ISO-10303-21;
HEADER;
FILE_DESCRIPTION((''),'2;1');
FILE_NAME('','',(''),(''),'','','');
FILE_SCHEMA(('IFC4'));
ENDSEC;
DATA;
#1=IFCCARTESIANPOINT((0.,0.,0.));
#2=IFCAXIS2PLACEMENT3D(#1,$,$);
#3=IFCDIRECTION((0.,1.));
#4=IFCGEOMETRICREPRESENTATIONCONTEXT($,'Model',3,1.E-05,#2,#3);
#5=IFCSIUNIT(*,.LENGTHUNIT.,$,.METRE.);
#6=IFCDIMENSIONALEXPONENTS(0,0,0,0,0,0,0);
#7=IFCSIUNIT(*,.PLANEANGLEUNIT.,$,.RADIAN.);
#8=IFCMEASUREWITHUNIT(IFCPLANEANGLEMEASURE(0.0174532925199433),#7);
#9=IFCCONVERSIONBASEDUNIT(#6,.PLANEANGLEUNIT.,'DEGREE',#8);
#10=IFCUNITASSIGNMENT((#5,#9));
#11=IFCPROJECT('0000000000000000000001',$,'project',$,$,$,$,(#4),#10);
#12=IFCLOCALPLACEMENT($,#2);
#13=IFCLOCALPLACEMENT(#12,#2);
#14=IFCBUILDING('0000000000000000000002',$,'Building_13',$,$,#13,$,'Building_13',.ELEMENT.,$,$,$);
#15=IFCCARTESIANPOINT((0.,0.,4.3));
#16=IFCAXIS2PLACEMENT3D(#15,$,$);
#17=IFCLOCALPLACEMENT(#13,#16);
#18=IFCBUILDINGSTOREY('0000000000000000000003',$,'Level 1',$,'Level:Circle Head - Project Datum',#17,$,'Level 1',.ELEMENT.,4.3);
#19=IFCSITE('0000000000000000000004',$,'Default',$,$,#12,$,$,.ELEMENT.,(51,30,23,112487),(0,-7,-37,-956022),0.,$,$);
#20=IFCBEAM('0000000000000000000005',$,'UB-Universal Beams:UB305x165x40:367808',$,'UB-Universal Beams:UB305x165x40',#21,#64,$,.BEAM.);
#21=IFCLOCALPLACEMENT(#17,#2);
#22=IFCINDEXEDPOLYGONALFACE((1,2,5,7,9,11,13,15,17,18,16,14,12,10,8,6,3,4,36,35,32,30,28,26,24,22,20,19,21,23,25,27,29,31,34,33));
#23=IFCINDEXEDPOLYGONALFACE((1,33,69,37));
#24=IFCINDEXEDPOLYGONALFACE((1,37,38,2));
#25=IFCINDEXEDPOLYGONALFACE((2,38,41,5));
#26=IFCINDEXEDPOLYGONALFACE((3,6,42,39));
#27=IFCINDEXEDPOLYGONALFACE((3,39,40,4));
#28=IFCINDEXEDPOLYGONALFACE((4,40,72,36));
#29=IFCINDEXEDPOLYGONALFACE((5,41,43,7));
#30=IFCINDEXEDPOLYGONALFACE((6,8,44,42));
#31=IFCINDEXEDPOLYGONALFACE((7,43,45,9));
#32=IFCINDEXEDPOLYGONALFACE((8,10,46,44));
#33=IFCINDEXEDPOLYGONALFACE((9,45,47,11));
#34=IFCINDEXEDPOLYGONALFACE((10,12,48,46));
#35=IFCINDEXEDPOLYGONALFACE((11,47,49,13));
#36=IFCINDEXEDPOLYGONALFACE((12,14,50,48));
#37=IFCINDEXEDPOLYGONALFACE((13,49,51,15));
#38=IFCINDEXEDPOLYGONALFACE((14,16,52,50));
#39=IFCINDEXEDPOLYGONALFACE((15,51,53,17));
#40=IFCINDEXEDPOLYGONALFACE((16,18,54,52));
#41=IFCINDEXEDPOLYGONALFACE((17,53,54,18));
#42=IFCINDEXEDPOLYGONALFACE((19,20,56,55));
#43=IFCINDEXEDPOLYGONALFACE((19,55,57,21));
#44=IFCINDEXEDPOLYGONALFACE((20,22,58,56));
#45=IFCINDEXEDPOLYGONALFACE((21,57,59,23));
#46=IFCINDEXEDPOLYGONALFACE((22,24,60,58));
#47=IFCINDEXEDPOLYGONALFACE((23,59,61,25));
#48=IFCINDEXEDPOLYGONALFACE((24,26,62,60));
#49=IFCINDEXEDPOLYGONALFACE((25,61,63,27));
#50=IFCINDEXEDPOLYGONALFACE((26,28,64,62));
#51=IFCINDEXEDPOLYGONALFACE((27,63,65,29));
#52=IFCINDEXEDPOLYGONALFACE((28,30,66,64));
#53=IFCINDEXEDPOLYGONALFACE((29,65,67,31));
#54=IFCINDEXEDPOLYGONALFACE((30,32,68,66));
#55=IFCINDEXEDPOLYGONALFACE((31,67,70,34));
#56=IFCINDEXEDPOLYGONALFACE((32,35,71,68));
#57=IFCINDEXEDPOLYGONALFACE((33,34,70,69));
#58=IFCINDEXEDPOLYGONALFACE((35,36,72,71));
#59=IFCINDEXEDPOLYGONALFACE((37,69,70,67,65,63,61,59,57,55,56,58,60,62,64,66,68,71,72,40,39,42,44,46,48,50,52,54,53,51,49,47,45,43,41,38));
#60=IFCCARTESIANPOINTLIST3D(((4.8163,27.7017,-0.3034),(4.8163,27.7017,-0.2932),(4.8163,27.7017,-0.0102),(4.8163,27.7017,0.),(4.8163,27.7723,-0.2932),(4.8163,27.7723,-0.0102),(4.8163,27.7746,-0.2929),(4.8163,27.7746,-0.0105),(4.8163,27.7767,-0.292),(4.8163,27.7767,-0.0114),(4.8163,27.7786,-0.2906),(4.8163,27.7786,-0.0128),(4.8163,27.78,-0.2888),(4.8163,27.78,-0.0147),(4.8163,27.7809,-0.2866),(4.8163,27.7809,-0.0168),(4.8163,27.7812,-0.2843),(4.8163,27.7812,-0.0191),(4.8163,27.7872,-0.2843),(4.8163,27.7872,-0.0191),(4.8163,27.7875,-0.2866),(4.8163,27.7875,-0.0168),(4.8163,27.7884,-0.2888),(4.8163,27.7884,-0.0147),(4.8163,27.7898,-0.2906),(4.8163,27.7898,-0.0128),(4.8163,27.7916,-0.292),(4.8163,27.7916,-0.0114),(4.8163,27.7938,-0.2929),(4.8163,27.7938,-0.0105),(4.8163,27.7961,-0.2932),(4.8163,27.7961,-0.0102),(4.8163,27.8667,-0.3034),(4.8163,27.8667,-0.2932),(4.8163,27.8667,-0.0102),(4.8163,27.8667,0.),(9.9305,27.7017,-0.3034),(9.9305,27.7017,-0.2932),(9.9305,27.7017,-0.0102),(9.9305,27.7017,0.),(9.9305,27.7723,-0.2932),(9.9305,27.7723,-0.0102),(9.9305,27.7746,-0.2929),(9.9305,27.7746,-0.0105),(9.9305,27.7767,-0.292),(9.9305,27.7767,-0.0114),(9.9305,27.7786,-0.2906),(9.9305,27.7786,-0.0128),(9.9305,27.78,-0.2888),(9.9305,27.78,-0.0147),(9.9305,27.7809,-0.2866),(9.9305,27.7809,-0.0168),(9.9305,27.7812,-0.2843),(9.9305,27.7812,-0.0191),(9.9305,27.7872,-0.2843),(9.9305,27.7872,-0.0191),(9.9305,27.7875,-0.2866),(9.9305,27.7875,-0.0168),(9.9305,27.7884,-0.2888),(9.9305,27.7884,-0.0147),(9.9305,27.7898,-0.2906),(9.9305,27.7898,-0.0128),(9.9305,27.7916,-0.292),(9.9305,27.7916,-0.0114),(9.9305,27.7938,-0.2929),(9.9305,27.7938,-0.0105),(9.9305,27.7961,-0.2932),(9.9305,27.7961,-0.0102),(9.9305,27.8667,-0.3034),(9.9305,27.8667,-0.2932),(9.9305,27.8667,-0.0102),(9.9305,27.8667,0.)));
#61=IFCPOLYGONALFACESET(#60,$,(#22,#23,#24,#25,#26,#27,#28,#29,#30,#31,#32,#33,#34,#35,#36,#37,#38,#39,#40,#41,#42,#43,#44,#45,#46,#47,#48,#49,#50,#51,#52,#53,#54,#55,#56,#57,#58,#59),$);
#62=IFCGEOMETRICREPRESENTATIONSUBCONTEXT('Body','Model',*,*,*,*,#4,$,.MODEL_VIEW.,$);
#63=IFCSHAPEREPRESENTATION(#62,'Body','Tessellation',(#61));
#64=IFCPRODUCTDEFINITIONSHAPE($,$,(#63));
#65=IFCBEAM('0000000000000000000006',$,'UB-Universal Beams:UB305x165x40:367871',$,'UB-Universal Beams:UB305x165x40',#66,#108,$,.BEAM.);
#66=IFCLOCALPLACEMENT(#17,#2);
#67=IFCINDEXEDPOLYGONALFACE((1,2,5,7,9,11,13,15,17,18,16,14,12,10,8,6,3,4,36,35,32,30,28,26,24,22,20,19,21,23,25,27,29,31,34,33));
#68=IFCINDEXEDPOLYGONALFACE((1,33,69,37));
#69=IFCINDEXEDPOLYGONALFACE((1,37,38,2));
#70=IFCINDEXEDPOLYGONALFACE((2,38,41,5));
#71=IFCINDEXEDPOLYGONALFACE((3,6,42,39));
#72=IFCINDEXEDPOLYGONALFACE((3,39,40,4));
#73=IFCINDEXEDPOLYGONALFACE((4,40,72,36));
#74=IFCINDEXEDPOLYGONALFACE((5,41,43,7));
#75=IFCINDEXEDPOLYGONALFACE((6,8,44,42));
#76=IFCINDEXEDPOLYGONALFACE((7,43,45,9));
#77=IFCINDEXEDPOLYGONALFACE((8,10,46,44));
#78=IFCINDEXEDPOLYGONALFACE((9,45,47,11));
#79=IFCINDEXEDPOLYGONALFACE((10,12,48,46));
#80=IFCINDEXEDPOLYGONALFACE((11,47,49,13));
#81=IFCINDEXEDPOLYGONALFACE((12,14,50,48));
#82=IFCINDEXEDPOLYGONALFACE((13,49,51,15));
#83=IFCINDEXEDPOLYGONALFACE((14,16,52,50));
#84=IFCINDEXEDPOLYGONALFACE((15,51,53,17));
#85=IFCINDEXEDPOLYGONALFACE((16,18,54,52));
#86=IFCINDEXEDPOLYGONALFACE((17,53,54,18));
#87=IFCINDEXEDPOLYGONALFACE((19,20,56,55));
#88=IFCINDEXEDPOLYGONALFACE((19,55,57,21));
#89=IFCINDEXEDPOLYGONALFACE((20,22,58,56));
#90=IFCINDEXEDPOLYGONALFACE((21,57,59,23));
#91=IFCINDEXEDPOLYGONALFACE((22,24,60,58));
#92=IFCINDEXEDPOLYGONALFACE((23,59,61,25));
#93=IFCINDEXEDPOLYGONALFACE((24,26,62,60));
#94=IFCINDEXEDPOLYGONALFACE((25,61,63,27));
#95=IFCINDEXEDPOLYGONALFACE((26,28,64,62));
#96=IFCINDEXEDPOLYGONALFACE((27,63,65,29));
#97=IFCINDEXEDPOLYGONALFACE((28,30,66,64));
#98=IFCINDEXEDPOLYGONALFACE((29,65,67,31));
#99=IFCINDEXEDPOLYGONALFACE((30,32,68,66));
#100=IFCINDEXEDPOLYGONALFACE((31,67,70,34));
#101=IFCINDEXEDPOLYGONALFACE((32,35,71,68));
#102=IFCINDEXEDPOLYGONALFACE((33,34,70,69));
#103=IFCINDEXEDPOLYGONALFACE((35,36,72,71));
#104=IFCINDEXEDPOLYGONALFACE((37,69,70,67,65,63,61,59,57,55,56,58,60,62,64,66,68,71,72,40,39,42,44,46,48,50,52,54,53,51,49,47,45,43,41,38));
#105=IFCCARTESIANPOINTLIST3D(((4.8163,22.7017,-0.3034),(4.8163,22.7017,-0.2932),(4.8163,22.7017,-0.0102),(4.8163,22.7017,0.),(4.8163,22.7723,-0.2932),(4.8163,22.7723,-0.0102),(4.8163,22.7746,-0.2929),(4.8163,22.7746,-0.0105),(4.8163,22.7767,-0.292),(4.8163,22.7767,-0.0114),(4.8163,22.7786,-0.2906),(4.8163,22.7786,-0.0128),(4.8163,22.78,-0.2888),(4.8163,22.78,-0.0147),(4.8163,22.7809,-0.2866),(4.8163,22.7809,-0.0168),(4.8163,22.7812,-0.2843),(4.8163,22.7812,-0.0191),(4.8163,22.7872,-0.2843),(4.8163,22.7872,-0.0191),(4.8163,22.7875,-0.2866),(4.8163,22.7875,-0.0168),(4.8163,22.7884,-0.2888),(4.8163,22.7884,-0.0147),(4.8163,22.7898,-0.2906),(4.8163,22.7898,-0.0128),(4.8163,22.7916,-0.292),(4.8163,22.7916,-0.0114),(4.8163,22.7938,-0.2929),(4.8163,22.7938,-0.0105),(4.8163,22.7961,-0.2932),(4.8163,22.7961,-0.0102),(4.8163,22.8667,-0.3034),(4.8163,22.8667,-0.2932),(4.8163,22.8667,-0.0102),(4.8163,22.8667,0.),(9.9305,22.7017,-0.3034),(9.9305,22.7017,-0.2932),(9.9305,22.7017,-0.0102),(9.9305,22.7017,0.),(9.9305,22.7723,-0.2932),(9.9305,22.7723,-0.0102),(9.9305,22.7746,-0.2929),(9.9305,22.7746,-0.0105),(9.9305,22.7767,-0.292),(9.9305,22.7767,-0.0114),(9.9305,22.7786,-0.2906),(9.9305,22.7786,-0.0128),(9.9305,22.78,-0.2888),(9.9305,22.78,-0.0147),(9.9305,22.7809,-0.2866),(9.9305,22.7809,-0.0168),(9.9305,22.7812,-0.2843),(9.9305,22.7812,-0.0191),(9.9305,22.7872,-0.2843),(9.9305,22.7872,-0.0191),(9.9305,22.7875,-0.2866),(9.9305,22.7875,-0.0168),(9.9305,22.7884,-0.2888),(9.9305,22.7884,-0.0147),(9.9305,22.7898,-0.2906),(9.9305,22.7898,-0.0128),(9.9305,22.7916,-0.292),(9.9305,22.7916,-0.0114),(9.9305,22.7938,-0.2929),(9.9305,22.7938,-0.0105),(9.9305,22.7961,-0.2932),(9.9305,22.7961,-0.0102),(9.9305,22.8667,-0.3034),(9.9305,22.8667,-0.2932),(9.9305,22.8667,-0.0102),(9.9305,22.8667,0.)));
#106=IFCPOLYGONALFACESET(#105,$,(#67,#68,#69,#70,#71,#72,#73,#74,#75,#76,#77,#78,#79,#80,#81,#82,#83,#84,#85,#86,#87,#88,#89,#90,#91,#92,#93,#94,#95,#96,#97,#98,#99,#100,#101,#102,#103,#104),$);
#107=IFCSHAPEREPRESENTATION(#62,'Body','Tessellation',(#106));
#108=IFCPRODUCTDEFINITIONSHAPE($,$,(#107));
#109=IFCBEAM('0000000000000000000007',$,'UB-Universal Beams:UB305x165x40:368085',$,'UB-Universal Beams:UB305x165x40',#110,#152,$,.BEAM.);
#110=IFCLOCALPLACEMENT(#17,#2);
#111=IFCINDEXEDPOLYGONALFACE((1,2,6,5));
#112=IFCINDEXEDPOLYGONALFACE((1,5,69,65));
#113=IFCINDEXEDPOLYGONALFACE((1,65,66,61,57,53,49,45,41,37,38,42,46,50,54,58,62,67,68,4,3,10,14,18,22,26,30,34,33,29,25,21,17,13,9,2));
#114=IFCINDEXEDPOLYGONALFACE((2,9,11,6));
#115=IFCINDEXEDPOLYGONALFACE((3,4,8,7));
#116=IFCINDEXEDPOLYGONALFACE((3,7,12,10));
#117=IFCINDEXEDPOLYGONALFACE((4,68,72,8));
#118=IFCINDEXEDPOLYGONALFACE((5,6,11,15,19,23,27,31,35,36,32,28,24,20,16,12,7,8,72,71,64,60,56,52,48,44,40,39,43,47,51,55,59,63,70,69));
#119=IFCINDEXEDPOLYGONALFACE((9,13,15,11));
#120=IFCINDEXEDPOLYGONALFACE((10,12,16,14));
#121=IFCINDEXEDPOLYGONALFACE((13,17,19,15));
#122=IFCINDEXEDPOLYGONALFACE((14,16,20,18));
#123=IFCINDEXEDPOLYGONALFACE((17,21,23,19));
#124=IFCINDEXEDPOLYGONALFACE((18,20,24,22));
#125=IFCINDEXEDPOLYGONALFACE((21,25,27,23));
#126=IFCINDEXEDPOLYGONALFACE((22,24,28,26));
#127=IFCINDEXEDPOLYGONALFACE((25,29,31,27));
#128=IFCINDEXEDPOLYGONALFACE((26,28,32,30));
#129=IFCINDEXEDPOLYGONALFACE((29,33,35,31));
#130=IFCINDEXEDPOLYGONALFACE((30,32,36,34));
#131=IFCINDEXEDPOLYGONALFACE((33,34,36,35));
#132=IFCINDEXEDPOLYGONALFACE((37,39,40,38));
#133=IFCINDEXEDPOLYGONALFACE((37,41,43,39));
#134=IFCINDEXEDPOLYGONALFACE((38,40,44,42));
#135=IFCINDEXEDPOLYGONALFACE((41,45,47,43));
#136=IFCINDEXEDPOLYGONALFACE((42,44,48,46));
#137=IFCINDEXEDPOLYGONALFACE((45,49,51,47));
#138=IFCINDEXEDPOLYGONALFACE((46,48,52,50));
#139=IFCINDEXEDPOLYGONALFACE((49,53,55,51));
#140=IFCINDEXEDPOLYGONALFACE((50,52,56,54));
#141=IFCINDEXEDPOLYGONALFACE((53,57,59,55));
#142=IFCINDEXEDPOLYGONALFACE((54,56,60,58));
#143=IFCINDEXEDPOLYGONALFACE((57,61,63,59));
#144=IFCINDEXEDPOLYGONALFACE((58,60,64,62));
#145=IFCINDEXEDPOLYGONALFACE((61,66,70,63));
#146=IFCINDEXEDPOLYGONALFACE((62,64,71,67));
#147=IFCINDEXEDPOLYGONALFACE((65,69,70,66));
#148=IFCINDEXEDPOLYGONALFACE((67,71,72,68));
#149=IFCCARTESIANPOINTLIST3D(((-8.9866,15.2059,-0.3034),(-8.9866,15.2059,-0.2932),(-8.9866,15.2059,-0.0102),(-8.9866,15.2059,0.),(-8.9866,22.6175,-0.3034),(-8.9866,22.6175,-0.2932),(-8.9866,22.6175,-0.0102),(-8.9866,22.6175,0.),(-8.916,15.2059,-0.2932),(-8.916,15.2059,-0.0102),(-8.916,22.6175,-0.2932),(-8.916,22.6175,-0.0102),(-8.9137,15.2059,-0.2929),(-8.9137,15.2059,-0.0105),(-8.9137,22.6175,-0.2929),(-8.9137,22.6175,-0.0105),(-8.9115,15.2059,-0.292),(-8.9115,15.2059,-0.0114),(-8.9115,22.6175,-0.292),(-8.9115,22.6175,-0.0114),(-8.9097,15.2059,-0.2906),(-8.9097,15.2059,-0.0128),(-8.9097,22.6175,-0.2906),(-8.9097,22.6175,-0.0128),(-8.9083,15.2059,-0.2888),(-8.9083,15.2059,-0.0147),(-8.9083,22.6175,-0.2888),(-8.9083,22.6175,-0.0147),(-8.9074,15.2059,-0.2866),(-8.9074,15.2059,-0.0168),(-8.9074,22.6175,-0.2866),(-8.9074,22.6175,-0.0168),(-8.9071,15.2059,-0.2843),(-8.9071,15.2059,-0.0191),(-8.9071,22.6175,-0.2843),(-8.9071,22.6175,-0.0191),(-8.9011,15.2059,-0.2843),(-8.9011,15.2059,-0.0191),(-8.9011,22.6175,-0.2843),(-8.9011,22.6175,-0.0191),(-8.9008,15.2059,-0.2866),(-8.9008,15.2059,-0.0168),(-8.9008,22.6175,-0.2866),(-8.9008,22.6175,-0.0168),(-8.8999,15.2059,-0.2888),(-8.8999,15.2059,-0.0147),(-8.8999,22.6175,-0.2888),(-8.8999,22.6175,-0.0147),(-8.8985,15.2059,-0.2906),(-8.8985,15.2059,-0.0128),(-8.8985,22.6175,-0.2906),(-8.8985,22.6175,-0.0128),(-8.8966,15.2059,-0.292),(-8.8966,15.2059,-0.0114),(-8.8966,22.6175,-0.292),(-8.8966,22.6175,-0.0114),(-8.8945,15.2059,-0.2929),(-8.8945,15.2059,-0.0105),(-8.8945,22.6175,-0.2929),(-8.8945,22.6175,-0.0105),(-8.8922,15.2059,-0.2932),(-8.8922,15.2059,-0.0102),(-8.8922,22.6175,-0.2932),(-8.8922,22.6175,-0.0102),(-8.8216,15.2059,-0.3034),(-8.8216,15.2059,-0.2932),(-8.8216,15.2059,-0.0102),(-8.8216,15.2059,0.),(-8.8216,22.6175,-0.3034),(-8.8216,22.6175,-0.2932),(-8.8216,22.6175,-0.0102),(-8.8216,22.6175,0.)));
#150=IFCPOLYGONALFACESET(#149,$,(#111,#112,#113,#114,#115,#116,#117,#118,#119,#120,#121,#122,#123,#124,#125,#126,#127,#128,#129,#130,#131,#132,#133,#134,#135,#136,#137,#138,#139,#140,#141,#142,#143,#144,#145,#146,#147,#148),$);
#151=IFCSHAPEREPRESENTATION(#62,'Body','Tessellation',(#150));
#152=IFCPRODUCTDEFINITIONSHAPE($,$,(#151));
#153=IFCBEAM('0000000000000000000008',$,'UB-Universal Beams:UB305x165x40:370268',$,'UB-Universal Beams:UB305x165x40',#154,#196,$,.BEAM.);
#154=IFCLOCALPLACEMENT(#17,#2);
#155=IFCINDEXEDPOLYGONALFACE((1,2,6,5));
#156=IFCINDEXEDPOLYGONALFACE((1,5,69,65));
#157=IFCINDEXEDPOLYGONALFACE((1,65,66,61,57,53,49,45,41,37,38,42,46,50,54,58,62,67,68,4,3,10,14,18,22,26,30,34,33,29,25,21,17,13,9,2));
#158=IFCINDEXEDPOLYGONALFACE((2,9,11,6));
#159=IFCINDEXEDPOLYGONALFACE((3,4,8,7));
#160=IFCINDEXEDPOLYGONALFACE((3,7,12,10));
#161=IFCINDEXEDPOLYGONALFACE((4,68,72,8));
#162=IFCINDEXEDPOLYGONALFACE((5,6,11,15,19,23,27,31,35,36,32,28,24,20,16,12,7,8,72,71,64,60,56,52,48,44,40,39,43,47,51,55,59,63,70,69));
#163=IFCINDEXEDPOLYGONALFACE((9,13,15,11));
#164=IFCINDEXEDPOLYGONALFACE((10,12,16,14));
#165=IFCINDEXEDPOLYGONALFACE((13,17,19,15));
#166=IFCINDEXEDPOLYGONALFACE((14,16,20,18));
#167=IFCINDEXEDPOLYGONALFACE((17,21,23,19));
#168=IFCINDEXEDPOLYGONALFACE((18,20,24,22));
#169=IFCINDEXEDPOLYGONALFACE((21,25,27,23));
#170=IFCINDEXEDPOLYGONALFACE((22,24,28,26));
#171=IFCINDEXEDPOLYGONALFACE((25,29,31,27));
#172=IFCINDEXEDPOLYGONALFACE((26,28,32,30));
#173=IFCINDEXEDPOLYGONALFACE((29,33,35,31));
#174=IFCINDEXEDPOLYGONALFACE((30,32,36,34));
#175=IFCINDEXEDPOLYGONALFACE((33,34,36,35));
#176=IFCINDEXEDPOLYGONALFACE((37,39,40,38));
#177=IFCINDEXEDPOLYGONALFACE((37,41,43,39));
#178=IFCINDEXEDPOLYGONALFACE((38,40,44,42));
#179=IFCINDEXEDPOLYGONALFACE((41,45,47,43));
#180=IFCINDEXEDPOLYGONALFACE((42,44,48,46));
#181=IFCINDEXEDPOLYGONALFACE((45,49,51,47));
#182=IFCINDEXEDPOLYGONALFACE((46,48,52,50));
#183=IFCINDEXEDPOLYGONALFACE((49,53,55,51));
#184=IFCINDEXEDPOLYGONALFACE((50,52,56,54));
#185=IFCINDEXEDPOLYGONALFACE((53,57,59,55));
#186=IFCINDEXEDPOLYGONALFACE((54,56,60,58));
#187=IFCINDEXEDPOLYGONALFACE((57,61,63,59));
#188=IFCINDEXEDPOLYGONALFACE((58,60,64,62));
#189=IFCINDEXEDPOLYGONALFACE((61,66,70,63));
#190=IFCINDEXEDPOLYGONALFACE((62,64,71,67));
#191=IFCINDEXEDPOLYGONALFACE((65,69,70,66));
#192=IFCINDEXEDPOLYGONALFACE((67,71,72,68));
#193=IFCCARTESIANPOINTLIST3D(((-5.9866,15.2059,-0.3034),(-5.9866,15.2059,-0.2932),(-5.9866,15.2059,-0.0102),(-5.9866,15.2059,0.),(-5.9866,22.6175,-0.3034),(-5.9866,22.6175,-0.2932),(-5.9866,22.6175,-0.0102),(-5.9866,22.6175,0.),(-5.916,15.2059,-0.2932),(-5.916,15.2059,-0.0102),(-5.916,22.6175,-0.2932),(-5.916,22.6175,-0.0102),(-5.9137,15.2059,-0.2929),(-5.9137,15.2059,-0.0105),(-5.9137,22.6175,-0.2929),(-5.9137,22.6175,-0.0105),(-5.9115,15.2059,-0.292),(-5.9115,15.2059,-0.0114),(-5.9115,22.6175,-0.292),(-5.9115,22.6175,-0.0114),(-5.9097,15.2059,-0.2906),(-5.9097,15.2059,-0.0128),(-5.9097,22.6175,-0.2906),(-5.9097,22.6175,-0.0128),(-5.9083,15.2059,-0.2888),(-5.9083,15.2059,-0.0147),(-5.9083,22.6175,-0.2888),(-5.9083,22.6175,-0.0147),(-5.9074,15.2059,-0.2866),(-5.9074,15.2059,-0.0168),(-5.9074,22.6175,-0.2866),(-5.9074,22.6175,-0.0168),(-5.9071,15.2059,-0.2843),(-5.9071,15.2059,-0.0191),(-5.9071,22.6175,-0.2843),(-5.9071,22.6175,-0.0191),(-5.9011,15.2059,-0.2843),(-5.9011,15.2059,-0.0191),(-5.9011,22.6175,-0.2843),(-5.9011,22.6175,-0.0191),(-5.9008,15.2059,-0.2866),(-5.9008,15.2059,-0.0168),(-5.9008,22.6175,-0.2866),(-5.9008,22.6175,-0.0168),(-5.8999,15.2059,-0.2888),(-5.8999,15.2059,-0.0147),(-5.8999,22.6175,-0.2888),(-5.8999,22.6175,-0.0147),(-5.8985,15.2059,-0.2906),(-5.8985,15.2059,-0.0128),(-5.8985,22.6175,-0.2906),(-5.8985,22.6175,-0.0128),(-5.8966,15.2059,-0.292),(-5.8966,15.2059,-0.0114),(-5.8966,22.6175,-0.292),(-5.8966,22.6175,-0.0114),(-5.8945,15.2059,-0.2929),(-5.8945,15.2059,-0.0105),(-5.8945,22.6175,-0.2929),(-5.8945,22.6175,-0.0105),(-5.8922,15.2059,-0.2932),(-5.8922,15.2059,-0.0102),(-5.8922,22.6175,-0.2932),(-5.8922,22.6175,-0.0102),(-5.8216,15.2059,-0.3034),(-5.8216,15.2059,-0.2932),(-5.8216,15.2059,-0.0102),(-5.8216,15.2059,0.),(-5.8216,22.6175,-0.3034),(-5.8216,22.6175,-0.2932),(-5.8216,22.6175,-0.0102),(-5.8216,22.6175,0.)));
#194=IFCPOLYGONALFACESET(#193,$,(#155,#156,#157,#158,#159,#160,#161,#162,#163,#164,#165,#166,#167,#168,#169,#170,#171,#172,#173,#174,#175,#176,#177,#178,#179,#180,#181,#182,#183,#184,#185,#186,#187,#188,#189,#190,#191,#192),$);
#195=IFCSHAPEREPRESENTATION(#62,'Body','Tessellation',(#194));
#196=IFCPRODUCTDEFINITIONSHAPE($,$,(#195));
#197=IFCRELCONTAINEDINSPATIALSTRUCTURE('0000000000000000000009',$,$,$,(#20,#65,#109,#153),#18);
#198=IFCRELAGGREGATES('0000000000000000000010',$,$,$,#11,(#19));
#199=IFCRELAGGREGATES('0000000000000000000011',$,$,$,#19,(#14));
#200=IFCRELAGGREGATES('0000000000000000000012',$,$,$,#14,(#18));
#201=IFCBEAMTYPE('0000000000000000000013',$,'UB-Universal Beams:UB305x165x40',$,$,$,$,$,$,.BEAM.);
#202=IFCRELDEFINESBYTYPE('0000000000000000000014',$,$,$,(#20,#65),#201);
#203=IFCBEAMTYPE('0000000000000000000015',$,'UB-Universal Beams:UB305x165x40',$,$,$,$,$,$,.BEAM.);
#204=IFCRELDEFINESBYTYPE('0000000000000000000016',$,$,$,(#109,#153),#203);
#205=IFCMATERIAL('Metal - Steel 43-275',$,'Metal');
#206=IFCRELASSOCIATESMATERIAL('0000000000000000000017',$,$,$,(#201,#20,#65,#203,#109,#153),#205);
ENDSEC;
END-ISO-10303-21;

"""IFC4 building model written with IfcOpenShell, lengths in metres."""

from ifc_helpers import new_model, entity, si_unit, converted_unit, direction, frame, origin, place, context, subcontext, project, spatial, line, arc, indexed_curve, outline, extrude, source, transform, mapped, material, type_object, type_shapes, element, save


model = new_model("IFC4")

# Units and contexts
model_context = context("Model", 3, precision=1e-05, world=origin(), true_north=direction((0.0, 1.0)))
body_context = subcontext(model_context, "Body", "Model", "MODEL_VIEW")
ifc_project = project(units=[si_unit("LENGTHUNIT", "METRE"), converted_unit("PLANEANGLEUNIT", "DEGREE", entity("IfcPlaneAngleMeasure", 0.0174532925199433), si_unit("PLANEANGLEUNIT", "RADIAN"), dimensions=[0, 0, 0, 0, 0, 0, 0])], contexts=[model_context])

# Site, building, storey
site_placement = place(None, origin())
site = spatial("IfcSite", under=ifc_project, at=site_placement, Name="Default", CompositionType="ELEMENT", RefLatitude=(51, 30, 23, 112487), RefLongitude=(0, -7, -37, -956022), RefElevation=0.0)
building_placement = place(site_placement, origin())
building = spatial("IfcBuilding", under=site, at=building_placement, Name="Building_13", LongName="Building_13", CompositionType="ELEMENT")
storey_placement = place(building_placement, frame((0.0, 0.0, 4.3)))
storey = spatial("IfcBuildingStorey", under=building, at=storey_placement, Name="Level 1", ObjectType="Level:Circle Head - Project Datum", LongName="Level 1", CompositionType="ELEMENT", Elevation=4.3)

# Beams
ifc_material_1 = material(Name="Metal - Steel 43-275", Category="Metal")
beam_type_1 = type_object("IfcBeamType", Name="UB-Universal Beams:UB305x165x40", PredefinedType="BEAM", material=ifc_material_1)
shared_shape_1 = source(origin(), body_context, "Body", "SweptSolid", [
    extrude(outline(indexed_curve([(-0.0825, -0.1415), (-0.0825, -0.1517), (0.0825, -0.1517), (0.0825, -0.1415), (0.0119, -0.1415), (0.0056, -0.1389), (0.003, -0.1326), (0.003, 0.1326), (0.0056, 0.1389), (0.0119, 0.1415), (0.0825, 0.1415), (0.0825, 0.1517), (-0.0825, 0.1517), (-0.0825, 0.1415), (-0.0119, 0.1415), (-0.0056, 0.1389), (-0.003, 0.1326), (-0.003, -0.1326), (-0.0056, -0.1389), (-0.0119, -0.1415)], segments=[line(1, 2, 3, 4, 5), arc(5, 6, 7), line(7, 8), arc(8, 9, 10), line(10, 11, 12, 13, 14, 15), arc(15, 16, 17), line(17, 18), arc(18, 19, 20), line(20, 1)], self_intersect=False)), frame((-2.5571, 0.0, 0.0), z_axis=(-1.0, 0.0, 0.0), x_axis=(0.0, -1.0, 0.0)), (0.0, 0.0, -1.0), 5.1142),
])
type_shapes(beam_type_1, [shared_shape_1])
for number, where, name in (
    (1, (7.3734, 27.7842, -0.1517), "UB-Universal Beams:UB305x165x40:367808"),
    (2, (7.3734, 22.7842, -0.1517), "UB-Universal Beams:UB305x165x40:367871"),
):
    element("IfcBeam", number, at=place(storey_placement, frame(where)), inside=storey, type_object=beam_type_1, material=ifc_material_1, Name=name, ObjectType="UB-Universal Beams:UB305x165x40", PredefinedType="BEAM", context=body_context, shape_type="MappedRepresentation", body=[
        mapped(shared_shape_1, transform((0.0, 0.0, 0.0), scale=1.0)),
    ])
beam_type_2 = type_object("IfcBeamType", Name="UB-Universal Beams:UB305x165x40", PredefinedType="BEAM", material=ifc_material_1)
shared_shape_2 = source(origin(), body_context, "Body", "SweptSolid", [
    extrude(outline(indexed_curve([(-0.0825, -0.1415), (-0.0825, -0.1517), (0.0825, -0.1517), (0.0825, -0.1415), (0.0119, -0.1415), (0.0056, -0.1389), (0.003, -0.1326), (0.003, 0.1326), (0.0056, 0.1389), (0.0119, 0.1415), (0.0825, 0.1415), (0.0825, 0.1517), (-0.0825, 0.1517), (-0.0825, 0.1415), (-0.0119, 0.1415), (-0.0056, 0.1389), (-0.003, 0.1326), (-0.003, -0.1326), (-0.0056, -0.1389), (-0.0119, -0.1415)], segments=[line(1, 2, 3, 4, 5), arc(5, 6, 7), line(7, 8), arc(8, 9, 10), line(10, 11, 12, 13, 14, 15), arc(15, 16, 17), line(17, 18), arc(18, 19, 20), line(20, 1)], self_intersect=False)), frame((-3.7058, 0.0, 0.0), z_axis=(-1.0, 0.0, 0.0), x_axis=(0.0, -1.0, 0.0)), (0.0, 0.0, -1.0), 7.4116),
])
type_shapes(beam_type_2, [shared_shape_2])
for number, where, z_axis, x_axis, name in (
    (3, (-8.9041, 18.9117, -0.1517), (0.0, 0.0, 1.0), (0.0, -1.0, 0.0), "UB-Universal Beams:UB305x165x40:368085"),
    (4, (-5.9041, 18.9117, -0.1517), (0.0, 0.0, 1.0), (0.0, -1.0, 0.0), "UB-Universal Beams:UB305x165x40:370268"),
):
    element("IfcBeam", number, at=place(storey_placement, frame(where, z_axis=z_axis, x_axis=x_axis)), inside=storey, type_object=beam_type_2, material=ifc_material_1, Name=name, ObjectType="UB-Universal Beams:UB305x165x40", PredefinedType="BEAM", context=body_context, shape_type="MappedRepresentation", body=[
        mapped(shared_shape_2, transform((0.0, 0.0, 0.0), scale=1.0)),
    ])

save(model, "model.ifc")
